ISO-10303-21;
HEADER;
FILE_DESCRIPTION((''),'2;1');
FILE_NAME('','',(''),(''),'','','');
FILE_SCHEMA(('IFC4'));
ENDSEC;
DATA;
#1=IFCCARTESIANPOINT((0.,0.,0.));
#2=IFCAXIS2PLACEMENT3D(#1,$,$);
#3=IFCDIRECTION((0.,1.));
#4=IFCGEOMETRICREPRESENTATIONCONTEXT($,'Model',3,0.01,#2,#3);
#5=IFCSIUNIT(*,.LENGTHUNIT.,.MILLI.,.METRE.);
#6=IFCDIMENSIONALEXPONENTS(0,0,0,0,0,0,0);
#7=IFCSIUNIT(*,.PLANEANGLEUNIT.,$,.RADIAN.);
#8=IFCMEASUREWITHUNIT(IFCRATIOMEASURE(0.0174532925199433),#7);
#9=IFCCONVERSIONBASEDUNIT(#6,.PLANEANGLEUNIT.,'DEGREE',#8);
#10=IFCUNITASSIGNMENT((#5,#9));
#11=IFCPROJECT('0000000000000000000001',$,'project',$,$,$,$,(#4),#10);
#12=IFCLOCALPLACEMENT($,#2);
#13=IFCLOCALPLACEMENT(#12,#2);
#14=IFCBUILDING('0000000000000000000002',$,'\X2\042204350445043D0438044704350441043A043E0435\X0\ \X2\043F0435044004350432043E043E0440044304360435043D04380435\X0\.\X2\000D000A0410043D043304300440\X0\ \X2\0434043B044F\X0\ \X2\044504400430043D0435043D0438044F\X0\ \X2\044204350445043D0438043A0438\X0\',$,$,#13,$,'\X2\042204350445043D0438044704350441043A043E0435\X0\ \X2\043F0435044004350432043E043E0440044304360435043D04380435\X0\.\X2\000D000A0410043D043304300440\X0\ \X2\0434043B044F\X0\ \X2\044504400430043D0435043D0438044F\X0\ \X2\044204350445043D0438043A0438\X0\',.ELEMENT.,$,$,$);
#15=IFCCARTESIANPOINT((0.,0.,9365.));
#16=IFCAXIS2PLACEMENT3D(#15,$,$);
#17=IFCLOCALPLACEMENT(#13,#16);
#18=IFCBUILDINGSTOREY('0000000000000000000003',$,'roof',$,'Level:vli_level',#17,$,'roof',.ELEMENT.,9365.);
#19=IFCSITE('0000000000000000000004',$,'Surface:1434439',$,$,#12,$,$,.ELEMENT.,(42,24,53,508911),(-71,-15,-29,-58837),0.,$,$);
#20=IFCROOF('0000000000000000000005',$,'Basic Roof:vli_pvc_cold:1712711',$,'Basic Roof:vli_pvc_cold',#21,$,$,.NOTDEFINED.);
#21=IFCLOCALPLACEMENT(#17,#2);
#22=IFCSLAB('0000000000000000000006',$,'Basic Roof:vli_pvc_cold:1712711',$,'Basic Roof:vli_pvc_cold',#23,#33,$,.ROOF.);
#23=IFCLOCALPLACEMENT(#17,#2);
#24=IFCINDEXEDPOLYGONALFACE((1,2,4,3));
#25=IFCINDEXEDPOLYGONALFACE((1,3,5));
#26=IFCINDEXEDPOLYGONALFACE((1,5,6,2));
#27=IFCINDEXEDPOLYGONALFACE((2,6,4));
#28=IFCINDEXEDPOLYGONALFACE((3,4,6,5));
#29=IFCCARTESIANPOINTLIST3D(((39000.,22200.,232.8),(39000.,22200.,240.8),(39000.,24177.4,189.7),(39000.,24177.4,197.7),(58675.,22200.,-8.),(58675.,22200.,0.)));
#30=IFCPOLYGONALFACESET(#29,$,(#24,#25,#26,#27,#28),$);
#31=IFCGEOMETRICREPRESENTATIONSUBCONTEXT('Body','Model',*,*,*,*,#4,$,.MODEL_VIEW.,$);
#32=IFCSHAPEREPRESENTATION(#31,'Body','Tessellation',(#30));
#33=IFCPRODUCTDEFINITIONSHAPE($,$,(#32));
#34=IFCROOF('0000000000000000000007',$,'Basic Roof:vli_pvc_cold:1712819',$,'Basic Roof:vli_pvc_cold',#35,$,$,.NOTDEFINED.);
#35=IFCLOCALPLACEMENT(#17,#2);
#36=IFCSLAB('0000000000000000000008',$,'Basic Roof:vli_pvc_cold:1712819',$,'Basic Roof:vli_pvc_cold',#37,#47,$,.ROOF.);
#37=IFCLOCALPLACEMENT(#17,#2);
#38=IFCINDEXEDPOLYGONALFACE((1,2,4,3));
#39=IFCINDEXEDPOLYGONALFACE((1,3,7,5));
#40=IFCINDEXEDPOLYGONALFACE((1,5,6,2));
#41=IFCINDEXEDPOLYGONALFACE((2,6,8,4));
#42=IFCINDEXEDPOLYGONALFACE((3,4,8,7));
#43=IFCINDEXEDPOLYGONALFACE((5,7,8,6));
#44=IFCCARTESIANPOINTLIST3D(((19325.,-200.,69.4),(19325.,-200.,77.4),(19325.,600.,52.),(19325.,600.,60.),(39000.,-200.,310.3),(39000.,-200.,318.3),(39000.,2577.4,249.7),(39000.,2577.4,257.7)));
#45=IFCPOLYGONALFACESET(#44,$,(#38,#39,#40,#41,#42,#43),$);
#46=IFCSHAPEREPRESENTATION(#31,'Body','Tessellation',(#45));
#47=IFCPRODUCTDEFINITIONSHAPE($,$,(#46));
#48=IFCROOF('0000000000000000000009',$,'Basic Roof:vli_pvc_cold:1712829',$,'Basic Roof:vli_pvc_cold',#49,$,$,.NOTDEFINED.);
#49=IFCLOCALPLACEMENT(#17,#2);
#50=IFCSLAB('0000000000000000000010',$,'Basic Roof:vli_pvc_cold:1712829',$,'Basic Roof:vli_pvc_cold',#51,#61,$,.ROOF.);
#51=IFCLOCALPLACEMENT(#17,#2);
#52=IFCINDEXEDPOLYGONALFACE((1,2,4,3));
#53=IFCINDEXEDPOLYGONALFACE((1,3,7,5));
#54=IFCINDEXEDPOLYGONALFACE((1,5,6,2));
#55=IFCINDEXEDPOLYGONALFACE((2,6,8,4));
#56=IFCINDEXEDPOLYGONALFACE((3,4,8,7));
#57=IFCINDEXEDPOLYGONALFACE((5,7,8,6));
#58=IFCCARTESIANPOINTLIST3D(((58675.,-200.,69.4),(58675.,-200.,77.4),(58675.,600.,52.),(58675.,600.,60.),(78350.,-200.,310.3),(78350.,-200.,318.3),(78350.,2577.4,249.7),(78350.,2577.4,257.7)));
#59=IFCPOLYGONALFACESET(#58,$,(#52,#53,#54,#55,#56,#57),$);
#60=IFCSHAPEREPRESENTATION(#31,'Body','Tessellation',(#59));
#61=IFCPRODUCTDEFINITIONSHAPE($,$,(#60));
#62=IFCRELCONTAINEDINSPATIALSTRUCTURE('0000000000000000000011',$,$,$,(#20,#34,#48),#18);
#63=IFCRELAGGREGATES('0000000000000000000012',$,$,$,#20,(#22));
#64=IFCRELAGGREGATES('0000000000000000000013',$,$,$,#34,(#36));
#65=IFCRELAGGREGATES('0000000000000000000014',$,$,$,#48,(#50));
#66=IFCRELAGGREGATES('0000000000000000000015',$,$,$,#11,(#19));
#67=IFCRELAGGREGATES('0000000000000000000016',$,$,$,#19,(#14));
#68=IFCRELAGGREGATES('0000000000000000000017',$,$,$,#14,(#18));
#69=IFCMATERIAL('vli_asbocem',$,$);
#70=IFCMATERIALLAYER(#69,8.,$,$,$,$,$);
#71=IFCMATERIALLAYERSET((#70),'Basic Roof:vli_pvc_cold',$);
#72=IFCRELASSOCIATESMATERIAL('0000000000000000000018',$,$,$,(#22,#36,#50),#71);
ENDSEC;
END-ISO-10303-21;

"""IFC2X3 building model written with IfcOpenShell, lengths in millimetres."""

from ifc_helpers import new_model, entity, si_unit, converted_unit, direction, frame, origin, place, context, subcontext, project, spatial, polyline, outline, extrude, material, layer, layer_set, element, aggregate, save


model = new_model("IFC2X3")

# Units and contexts
model_context = context("Model", 3, precision=0.01, world=origin(), true_north=direction((0.0, 1.0)))
body_context = subcontext(model_context, "Body", "Model", "MODEL_VIEW")
ifc_project = project(units=[si_unit("LENGTHUNIT", "METRE", prefix="MILLI"), converted_unit("PLANEANGLEUNIT", "DEGREE", entity("IfcRatioMeasure", 0.0174532925199433), si_unit("PLANEANGLEUNIT", "RADIAN"), dimensions=[0, 0, 0, 0, 0, 0, 0])], contexts=[model_context])

# Site, building, storey
site_placement = place(None, origin())
site = spatial("IfcSite", under=ifc_project, at=site_placement, Name="Surface:1434439", CompositionType="ELEMENT", RefLatitude=(42, 24, 53, 508911), RefLongitude=(-71, -15, -29, -58837), RefElevation=0.0)
building_placement = place(site_placement, origin())
building = spatial("IfcBuilding", under=site, at=building_placement, Name="Техническое перевооружение.\r\nАнгар для хранения техники", LongName="Техническое перевооружение.\r\nАнгар для хранения техники", CompositionType="ELEMENT")
storey_placement = place(building_placement, frame((0.0, 0.0, 9365.0)))
storey = spatial("IfcBuildingStorey", under=building, at=storey_placement, Name="roof", ObjectType="Level:vli_level", LongName="roof", CompositionType="ELEMENT", Elevation=9365.0)

# Roof, slab
roof_1_placement = place(storey_placement, frame((39000.0, 20222.6, -8.0)))
roof_1 = element("IfcRoof", 1, at=roof_1_placement, inside=storey, Name="Basic Roof:vli_pvc_cold:1712711", ObjectType="Basic Roof:vli_pvc_cold", ShapeType="NOTDEFINED")
ifc_material_1 = material(Name="vli_asbocem")
ifc_layer = layer(ifc_material_1, 8.0)
ifc_layer_set = layer_set([ifc_layer], Name="Basic Roof:vli_pvc_cold")
slab_1_placement = place(roof_1_placement, origin())
slab_1 = element("IfcSlab", 2, at=slab_1_placement, material=ifc_layer_set, Name="Basic Roof:vli_pvc_cold:1712711", ObjectType="Basic Roof:vli_pvc_cold", PredefinedType="ROOF", context=body_context, shape_type="SweptSolid", body=[
    extrude(outline(polyline([(-9838.2, 988.9), (-9838.2, -988.9), (9838.2, -983.7), (-9838.2, 988.9)])), frame((9837.5, 2963.5, 98.9), z_axis=(0.012237, 0.021791, 0.999688), x_axis=(0.999925, -0.000267, -0.012234)), (-0.012234, -0.021793, 0.999688), 8.0),
])
aggregate(roof_1, [slab_1])

# Roofs, slabs
roof_2_placement = place(storey_placement, frame((19325.0, -200.0, 52.0)))
roof_2 = element("IfcRoof", 3, at=roof_2_placement, inside=storey, Name="Basic Roof:vli_pvc_cold:1712819", ObjectType="Basic Roof:vli_pvc_cold", ShapeType="NOTDEFINED")
slab_2_placement = place(roof_2_placement, origin())
slab_2 = element("IfcSlab", 4, at=slab_2_placement, material=ifc_layer_set, Name="Basic Roof:vli_pvc_cold:1712819", ObjectType="Basic Roof:vli_pvc_cold", PredefinedType="ROOF", context=body_context, shape_type="SweptSolid", body=[
    extrude(outline(polyline([(9838.2, -1389.0), (9838.2, 1389.0), (-9838.2, -583.6), (-9838.2, -1383.8), (9838.2, -1389.0)])), frame((9837.5, 1386.1, 107.6), z_axis=(-0.012237, 0.021791, 0.999688), x_axis=(0.999925, 0.000267, 0.012234)), (0.012234, -0.021793, 0.999688), 8.0),
])
aggregate(roof_2, [slab_2])
roof_3_placement = place(storey_placement, frame((58675.0, -200.0, 52.0)))
roof_3 = element("IfcRoof", 5, at=roof_3_placement, inside=storey, Name="Basic Roof:vli_pvc_cold:1712829", ObjectType="Basic Roof:vli_pvc_cold", ShapeType="NOTDEFINED")
slab_3_placement = place(roof_3_placement, origin())
slab_3 = element("IfcSlab", 6, at=slab_3_placement, material=ifc_layer_set, Name="Basic Roof:vli_pvc_cold:1712829", ObjectType="Basic Roof:vli_pvc_cold", PredefinedType="ROOF", context=body_context, shape_type="SweptSolid", body=[
    extrude(outline(polyline([(9838.2, -1389.0), (9838.2, 1389.0), (-9838.2, -583.6), (-9838.2, -1383.8), (9838.2, -1389.0)])), frame((9837.5, 1386.1, 107.6), z_axis=(-0.012237, 0.021791, 0.999688), x_axis=(0.999925, 0.000267, 0.012234)), (0.012234, -0.021793, 0.999688), 8.0),
])
aggregate(roof_3, [slab_3])

save(model, "model.ifc")
